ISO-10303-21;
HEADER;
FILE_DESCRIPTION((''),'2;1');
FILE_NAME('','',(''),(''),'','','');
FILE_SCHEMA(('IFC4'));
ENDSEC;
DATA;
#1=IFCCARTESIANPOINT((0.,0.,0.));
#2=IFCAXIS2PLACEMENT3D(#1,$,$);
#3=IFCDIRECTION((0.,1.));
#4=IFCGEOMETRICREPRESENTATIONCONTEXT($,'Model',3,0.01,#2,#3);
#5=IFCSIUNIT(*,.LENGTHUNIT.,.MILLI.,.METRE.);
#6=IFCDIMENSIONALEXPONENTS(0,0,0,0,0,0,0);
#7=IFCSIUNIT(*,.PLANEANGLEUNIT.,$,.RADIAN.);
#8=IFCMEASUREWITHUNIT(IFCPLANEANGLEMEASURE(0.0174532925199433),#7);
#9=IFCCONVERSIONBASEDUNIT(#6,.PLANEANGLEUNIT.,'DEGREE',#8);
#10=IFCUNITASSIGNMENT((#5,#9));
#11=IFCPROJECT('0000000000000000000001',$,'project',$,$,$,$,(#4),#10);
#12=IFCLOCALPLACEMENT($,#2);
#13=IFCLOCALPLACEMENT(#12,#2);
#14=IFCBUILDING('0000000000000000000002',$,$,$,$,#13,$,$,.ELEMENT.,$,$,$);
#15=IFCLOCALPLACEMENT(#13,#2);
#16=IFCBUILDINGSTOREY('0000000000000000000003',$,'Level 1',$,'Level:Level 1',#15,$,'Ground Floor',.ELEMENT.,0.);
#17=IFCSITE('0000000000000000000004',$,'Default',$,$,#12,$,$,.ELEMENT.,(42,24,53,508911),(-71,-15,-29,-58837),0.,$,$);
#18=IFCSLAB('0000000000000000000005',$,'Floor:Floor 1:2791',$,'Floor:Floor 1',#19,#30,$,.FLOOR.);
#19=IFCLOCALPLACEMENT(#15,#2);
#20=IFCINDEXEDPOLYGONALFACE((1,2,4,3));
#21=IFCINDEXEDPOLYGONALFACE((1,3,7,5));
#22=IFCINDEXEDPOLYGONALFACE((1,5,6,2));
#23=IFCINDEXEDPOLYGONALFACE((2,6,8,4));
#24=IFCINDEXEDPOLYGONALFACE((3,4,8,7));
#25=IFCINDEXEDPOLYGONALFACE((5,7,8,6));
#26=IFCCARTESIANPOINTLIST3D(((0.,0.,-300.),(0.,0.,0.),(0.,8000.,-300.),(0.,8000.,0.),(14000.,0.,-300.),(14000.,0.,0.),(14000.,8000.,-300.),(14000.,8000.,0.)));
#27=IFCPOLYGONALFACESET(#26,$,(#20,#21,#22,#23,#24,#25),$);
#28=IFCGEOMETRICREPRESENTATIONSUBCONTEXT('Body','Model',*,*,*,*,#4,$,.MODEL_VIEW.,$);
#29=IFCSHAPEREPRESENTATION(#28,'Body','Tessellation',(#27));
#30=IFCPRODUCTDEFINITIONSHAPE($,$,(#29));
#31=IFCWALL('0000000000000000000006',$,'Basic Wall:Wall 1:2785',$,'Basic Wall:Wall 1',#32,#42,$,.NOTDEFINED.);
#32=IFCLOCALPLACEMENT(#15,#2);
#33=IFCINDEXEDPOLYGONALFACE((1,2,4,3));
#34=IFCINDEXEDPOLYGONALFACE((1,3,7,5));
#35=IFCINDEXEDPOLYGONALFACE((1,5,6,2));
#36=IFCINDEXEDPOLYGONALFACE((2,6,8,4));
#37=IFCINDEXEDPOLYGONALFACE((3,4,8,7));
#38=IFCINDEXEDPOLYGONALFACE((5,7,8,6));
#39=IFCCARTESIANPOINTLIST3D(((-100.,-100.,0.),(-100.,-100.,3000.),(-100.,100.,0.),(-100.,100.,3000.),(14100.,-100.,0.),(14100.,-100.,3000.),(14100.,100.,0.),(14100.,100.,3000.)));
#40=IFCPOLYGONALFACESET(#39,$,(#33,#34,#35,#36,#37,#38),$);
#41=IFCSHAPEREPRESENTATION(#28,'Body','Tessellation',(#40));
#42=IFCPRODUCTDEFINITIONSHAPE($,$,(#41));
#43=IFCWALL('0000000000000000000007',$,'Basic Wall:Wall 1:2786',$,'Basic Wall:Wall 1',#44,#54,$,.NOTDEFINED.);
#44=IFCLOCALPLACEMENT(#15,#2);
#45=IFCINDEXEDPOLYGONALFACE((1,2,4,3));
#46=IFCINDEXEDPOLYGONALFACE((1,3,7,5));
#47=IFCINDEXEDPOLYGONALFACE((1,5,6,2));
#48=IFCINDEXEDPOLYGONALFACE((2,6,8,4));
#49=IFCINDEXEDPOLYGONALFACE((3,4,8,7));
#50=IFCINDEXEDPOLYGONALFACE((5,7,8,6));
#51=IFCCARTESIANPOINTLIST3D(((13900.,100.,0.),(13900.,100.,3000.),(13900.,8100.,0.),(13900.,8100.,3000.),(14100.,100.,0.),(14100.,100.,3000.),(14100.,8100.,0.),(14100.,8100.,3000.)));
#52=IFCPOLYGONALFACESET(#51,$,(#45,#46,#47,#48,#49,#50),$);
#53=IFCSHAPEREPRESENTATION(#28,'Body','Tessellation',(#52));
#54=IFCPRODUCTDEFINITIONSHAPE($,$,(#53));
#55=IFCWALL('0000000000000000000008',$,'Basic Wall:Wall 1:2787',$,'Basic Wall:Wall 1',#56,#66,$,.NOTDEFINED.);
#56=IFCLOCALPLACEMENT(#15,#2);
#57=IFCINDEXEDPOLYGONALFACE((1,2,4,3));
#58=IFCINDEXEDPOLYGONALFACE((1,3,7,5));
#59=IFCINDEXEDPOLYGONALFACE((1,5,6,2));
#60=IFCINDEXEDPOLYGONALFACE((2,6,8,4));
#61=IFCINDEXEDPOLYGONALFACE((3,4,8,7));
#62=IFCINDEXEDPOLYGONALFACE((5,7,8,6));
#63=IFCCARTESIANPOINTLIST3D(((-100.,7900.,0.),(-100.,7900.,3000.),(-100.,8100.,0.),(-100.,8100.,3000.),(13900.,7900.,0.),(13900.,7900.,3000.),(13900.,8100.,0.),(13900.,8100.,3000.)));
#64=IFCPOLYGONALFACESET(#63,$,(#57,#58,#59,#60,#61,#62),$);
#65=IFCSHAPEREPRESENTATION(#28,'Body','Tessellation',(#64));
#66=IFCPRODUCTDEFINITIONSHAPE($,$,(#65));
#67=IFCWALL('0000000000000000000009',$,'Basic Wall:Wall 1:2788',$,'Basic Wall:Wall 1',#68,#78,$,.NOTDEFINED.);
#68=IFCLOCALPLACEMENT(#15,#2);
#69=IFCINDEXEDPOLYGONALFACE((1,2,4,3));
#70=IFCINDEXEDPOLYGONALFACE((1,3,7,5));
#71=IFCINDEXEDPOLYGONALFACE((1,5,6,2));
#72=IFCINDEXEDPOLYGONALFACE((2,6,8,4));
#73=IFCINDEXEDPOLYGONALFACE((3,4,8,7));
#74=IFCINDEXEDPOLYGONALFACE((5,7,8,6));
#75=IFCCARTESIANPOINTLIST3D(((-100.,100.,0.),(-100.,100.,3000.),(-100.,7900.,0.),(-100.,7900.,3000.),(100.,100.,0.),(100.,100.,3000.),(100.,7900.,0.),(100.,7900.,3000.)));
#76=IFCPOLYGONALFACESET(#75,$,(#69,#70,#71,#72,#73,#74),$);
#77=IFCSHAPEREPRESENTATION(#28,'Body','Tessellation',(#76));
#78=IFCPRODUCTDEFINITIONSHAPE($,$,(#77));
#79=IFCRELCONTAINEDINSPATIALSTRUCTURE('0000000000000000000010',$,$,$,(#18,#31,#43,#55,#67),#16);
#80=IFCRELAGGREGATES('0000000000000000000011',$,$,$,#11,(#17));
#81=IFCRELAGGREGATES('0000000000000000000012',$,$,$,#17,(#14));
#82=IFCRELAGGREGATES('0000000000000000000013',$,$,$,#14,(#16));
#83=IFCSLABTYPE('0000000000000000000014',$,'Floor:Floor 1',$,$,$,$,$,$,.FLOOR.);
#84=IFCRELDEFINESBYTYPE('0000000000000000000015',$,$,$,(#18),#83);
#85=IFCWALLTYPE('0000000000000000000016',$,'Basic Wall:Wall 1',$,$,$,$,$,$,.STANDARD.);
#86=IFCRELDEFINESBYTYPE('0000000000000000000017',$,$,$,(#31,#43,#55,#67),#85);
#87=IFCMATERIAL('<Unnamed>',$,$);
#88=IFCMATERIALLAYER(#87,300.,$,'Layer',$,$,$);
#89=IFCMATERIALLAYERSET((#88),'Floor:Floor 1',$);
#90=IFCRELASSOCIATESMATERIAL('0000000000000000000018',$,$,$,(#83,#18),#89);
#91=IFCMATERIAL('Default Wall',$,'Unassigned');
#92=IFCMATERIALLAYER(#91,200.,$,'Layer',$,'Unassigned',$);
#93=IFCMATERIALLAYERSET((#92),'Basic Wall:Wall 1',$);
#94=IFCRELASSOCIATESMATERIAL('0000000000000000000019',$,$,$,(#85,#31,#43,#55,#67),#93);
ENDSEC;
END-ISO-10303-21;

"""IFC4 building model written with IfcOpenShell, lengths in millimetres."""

from ifc_helpers import new_model, entity, si_unit, converted_unit, direction, frame, frame_2d, origin, origin_2d_with_axis, place, context, subcontext, project, spatial, rectangle, extrude, material, layer, layer_set, layer_usage, type_object, element, save


model = new_model("IFC4")

# Units and contexts
model_context = context("Model", 3, precision=0.01, world=origin(), true_north=direction((0.0, 1.0)))
body_context = subcontext(model_context, "Body", "Model", "MODEL_VIEW")
ifc_project = project(units=[si_unit("LENGTHUNIT", "METRE", prefix="MILLI"), converted_unit("PLANEANGLEUNIT", "DEGREE", entity("IfcPlaneAngleMeasure", 0.0174532925199433), si_unit("PLANEANGLEUNIT", "RADIAN"), dimensions=[0, 0, 0, 0, 0, 0, 0])], contexts=[model_context])

# Site, building, storey
site_placement = place(None, origin())
site = spatial("IfcSite", under=ifc_project, at=site_placement, Name="Default", CompositionType="ELEMENT", RefLatitude=(42, 24, 53, 508911), RefLongitude=(-71, -15, -29, -58837), RefElevation=0.0)
building_placement = place(site_placement, origin())
building = spatial("IfcBuilding", under=site, at=building_placement, CompositionType="ELEMENT")
storey_placement = place(building_placement, origin())
storey = spatial("IfcBuildingStorey", under=building, at=storey_placement, Name="Level 1", ObjectType="Level:Level 1", LongName="Ground Floor", CompositionType="ELEMENT", Elevation=0.0)

# Shared definitions
ifc_material_1 = material(Name="Default Wall", Category="Unassigned")

# Slab
ifc_material_2 = material(Name="<Unnamed>")
ifc_layer_1 = layer(ifc_material_2, 300.0, Name="Layer")
ifc_layer_set_1 = layer_set([ifc_layer_1], Name="Floor:Floor 1")
ifc_layer_usage_1 = layer_usage(ifc_layer_set_1, "AXIS3", "POSITIVE", 0.0)
slab_type = type_object("IfcSlabType", Name="Floor:Floor 1", PredefinedType="FLOOR", material=ifc_layer_set_1)
slab_placement = place(storey_placement, origin())
element("IfcSlab", 1, at=slab_placement, inside=storey, type_object=slab_type, material=ifc_layer_usage_1, Name="Floor:Floor 1:2791", ObjectType="Floor:Floor 1", PredefinedType="FLOOR", context=body_context, shape_type="SweptSolid", body=[
    extrude(rectangle(XDim=8000.0, YDim=14000.0, at=origin_2d_with_axis()), frame((7000.0, 4000.0, 0.0), z_axis=(0.0, 0.0, -1.0), x_axis=(0.0, 1.0, 0.0)), (0.0, 0.0, 1.0), 300.0),
])

# Walls
ifc_layer_2 = layer(ifc_material_1, 200.0, Name="Layer", Category="Unassigned")
ifc_layer_set_2 = layer_set([ifc_layer_2], Name="Basic Wall:Wall 1")
ifc_layer_usage_2 = layer_usage(ifc_layer_set_2, "AXIS2", "NEGATIVE", 100.0)
wall_type = type_object("IfcWallType", Name="Basic Wall:Wall 1", PredefinedType="STANDARD", material=ifc_layer_set_2)
wall_1_placement = place(storey_placement, frame((-100.0, 0.0, 0.0)))
element("IfcWall", 2, at=wall_1_placement, inside=storey, type_object=wall_type, material=ifc_layer_usage_2, Name="Basic Wall:Wall 1:2785", ObjectType="Basic Wall:Wall 1", PredefinedType="NOTDEFINED", context=body_context, shape_type="SweptSolid", body=[
    extrude(rectangle(XDim=14200.0, YDim=200.0, at=frame_2d((7100.0, 0.0), x_axis=(-1.0, 0.0))), origin(), (0.0, 0.0, 1.0), 3000.0),
])
ifc_layer_usage_3 = layer_usage(ifc_layer_set_2, "AXIS2", "NEGATIVE", 100.0)
wall_2_placement = place(storey_placement, frame((14000.0, 100.0, 0.0), z_axis=(0.0, 0.0, 1.0), x_axis=(0.0, 1.0, 0.0)))
element("IfcWall", 3, at=wall_2_placement, inside=storey, type_object=wall_type, material=ifc_layer_usage_3, Name="Basic Wall:Wall 1:2786", ObjectType="Basic Wall:Wall 1", PredefinedType="NOTDEFINED", context=body_context, shape_type="SweptSolid", body=[
    extrude(rectangle(XDim=8000.0, YDim=200.0, at=frame_2d((4000.0, 0.0), x_axis=(-1.0, 0.0))), origin(), (0.0, 0.0, 1.0), 3000.0),
])
ifc_layer_usage_4 = layer_usage(ifc_layer_set_2, "AXIS2", "NEGATIVE", 100.0)
wall_3_placement = place(storey_placement, frame((13900.0, 8000.0, 0.0), z_axis=(0.0, 0.0, 1.0), x_axis=(-1.0, 0.0, 0.0)))
element("IfcWall", 4, at=wall_3_placement, inside=storey, type_object=wall_type, material=ifc_layer_usage_4, Name="Basic Wall:Wall 1:2787", ObjectType="Basic Wall:Wall 1", PredefinedType="NOTDEFINED", context=body_context, shape_type="SweptSolid", body=[
    extrude(rectangle(XDim=14000.0, YDim=200.0, at=frame_2d((7000.0, 0.0), x_axis=(-1.0, 0.0))), origin(), (0.0, 0.0, 1.0), 3000.0),
])
ifc_layer_usage_5 = layer_usage(ifc_layer_set_2, "AXIS2", "NEGATIVE", 100.0)
wall_4_placement = place(storey_placement, frame((0.0, 7900.0, 0.0), z_axis=(0.0, 0.0, 1.0), x_axis=(0.0, -1.0, 0.0)))
element("IfcWall", 5, at=wall_4_placement, inside=storey, type_object=wall_type, material=ifc_layer_usage_5, Name="Basic Wall:Wall 1:2788", ObjectType="Basic Wall:Wall 1", PredefinedType="NOTDEFINED", context=body_context, shape_type="SweptSolid", body=[
    extrude(rectangle(XDim=7800.0, YDim=200.0, at=frame_2d((3900.0, 0.0), x_axis=(-1.0, 0.0))), origin(), (0.0, 0.0, 1.0), 3000.0),
])

save(model, "model.ifc")
